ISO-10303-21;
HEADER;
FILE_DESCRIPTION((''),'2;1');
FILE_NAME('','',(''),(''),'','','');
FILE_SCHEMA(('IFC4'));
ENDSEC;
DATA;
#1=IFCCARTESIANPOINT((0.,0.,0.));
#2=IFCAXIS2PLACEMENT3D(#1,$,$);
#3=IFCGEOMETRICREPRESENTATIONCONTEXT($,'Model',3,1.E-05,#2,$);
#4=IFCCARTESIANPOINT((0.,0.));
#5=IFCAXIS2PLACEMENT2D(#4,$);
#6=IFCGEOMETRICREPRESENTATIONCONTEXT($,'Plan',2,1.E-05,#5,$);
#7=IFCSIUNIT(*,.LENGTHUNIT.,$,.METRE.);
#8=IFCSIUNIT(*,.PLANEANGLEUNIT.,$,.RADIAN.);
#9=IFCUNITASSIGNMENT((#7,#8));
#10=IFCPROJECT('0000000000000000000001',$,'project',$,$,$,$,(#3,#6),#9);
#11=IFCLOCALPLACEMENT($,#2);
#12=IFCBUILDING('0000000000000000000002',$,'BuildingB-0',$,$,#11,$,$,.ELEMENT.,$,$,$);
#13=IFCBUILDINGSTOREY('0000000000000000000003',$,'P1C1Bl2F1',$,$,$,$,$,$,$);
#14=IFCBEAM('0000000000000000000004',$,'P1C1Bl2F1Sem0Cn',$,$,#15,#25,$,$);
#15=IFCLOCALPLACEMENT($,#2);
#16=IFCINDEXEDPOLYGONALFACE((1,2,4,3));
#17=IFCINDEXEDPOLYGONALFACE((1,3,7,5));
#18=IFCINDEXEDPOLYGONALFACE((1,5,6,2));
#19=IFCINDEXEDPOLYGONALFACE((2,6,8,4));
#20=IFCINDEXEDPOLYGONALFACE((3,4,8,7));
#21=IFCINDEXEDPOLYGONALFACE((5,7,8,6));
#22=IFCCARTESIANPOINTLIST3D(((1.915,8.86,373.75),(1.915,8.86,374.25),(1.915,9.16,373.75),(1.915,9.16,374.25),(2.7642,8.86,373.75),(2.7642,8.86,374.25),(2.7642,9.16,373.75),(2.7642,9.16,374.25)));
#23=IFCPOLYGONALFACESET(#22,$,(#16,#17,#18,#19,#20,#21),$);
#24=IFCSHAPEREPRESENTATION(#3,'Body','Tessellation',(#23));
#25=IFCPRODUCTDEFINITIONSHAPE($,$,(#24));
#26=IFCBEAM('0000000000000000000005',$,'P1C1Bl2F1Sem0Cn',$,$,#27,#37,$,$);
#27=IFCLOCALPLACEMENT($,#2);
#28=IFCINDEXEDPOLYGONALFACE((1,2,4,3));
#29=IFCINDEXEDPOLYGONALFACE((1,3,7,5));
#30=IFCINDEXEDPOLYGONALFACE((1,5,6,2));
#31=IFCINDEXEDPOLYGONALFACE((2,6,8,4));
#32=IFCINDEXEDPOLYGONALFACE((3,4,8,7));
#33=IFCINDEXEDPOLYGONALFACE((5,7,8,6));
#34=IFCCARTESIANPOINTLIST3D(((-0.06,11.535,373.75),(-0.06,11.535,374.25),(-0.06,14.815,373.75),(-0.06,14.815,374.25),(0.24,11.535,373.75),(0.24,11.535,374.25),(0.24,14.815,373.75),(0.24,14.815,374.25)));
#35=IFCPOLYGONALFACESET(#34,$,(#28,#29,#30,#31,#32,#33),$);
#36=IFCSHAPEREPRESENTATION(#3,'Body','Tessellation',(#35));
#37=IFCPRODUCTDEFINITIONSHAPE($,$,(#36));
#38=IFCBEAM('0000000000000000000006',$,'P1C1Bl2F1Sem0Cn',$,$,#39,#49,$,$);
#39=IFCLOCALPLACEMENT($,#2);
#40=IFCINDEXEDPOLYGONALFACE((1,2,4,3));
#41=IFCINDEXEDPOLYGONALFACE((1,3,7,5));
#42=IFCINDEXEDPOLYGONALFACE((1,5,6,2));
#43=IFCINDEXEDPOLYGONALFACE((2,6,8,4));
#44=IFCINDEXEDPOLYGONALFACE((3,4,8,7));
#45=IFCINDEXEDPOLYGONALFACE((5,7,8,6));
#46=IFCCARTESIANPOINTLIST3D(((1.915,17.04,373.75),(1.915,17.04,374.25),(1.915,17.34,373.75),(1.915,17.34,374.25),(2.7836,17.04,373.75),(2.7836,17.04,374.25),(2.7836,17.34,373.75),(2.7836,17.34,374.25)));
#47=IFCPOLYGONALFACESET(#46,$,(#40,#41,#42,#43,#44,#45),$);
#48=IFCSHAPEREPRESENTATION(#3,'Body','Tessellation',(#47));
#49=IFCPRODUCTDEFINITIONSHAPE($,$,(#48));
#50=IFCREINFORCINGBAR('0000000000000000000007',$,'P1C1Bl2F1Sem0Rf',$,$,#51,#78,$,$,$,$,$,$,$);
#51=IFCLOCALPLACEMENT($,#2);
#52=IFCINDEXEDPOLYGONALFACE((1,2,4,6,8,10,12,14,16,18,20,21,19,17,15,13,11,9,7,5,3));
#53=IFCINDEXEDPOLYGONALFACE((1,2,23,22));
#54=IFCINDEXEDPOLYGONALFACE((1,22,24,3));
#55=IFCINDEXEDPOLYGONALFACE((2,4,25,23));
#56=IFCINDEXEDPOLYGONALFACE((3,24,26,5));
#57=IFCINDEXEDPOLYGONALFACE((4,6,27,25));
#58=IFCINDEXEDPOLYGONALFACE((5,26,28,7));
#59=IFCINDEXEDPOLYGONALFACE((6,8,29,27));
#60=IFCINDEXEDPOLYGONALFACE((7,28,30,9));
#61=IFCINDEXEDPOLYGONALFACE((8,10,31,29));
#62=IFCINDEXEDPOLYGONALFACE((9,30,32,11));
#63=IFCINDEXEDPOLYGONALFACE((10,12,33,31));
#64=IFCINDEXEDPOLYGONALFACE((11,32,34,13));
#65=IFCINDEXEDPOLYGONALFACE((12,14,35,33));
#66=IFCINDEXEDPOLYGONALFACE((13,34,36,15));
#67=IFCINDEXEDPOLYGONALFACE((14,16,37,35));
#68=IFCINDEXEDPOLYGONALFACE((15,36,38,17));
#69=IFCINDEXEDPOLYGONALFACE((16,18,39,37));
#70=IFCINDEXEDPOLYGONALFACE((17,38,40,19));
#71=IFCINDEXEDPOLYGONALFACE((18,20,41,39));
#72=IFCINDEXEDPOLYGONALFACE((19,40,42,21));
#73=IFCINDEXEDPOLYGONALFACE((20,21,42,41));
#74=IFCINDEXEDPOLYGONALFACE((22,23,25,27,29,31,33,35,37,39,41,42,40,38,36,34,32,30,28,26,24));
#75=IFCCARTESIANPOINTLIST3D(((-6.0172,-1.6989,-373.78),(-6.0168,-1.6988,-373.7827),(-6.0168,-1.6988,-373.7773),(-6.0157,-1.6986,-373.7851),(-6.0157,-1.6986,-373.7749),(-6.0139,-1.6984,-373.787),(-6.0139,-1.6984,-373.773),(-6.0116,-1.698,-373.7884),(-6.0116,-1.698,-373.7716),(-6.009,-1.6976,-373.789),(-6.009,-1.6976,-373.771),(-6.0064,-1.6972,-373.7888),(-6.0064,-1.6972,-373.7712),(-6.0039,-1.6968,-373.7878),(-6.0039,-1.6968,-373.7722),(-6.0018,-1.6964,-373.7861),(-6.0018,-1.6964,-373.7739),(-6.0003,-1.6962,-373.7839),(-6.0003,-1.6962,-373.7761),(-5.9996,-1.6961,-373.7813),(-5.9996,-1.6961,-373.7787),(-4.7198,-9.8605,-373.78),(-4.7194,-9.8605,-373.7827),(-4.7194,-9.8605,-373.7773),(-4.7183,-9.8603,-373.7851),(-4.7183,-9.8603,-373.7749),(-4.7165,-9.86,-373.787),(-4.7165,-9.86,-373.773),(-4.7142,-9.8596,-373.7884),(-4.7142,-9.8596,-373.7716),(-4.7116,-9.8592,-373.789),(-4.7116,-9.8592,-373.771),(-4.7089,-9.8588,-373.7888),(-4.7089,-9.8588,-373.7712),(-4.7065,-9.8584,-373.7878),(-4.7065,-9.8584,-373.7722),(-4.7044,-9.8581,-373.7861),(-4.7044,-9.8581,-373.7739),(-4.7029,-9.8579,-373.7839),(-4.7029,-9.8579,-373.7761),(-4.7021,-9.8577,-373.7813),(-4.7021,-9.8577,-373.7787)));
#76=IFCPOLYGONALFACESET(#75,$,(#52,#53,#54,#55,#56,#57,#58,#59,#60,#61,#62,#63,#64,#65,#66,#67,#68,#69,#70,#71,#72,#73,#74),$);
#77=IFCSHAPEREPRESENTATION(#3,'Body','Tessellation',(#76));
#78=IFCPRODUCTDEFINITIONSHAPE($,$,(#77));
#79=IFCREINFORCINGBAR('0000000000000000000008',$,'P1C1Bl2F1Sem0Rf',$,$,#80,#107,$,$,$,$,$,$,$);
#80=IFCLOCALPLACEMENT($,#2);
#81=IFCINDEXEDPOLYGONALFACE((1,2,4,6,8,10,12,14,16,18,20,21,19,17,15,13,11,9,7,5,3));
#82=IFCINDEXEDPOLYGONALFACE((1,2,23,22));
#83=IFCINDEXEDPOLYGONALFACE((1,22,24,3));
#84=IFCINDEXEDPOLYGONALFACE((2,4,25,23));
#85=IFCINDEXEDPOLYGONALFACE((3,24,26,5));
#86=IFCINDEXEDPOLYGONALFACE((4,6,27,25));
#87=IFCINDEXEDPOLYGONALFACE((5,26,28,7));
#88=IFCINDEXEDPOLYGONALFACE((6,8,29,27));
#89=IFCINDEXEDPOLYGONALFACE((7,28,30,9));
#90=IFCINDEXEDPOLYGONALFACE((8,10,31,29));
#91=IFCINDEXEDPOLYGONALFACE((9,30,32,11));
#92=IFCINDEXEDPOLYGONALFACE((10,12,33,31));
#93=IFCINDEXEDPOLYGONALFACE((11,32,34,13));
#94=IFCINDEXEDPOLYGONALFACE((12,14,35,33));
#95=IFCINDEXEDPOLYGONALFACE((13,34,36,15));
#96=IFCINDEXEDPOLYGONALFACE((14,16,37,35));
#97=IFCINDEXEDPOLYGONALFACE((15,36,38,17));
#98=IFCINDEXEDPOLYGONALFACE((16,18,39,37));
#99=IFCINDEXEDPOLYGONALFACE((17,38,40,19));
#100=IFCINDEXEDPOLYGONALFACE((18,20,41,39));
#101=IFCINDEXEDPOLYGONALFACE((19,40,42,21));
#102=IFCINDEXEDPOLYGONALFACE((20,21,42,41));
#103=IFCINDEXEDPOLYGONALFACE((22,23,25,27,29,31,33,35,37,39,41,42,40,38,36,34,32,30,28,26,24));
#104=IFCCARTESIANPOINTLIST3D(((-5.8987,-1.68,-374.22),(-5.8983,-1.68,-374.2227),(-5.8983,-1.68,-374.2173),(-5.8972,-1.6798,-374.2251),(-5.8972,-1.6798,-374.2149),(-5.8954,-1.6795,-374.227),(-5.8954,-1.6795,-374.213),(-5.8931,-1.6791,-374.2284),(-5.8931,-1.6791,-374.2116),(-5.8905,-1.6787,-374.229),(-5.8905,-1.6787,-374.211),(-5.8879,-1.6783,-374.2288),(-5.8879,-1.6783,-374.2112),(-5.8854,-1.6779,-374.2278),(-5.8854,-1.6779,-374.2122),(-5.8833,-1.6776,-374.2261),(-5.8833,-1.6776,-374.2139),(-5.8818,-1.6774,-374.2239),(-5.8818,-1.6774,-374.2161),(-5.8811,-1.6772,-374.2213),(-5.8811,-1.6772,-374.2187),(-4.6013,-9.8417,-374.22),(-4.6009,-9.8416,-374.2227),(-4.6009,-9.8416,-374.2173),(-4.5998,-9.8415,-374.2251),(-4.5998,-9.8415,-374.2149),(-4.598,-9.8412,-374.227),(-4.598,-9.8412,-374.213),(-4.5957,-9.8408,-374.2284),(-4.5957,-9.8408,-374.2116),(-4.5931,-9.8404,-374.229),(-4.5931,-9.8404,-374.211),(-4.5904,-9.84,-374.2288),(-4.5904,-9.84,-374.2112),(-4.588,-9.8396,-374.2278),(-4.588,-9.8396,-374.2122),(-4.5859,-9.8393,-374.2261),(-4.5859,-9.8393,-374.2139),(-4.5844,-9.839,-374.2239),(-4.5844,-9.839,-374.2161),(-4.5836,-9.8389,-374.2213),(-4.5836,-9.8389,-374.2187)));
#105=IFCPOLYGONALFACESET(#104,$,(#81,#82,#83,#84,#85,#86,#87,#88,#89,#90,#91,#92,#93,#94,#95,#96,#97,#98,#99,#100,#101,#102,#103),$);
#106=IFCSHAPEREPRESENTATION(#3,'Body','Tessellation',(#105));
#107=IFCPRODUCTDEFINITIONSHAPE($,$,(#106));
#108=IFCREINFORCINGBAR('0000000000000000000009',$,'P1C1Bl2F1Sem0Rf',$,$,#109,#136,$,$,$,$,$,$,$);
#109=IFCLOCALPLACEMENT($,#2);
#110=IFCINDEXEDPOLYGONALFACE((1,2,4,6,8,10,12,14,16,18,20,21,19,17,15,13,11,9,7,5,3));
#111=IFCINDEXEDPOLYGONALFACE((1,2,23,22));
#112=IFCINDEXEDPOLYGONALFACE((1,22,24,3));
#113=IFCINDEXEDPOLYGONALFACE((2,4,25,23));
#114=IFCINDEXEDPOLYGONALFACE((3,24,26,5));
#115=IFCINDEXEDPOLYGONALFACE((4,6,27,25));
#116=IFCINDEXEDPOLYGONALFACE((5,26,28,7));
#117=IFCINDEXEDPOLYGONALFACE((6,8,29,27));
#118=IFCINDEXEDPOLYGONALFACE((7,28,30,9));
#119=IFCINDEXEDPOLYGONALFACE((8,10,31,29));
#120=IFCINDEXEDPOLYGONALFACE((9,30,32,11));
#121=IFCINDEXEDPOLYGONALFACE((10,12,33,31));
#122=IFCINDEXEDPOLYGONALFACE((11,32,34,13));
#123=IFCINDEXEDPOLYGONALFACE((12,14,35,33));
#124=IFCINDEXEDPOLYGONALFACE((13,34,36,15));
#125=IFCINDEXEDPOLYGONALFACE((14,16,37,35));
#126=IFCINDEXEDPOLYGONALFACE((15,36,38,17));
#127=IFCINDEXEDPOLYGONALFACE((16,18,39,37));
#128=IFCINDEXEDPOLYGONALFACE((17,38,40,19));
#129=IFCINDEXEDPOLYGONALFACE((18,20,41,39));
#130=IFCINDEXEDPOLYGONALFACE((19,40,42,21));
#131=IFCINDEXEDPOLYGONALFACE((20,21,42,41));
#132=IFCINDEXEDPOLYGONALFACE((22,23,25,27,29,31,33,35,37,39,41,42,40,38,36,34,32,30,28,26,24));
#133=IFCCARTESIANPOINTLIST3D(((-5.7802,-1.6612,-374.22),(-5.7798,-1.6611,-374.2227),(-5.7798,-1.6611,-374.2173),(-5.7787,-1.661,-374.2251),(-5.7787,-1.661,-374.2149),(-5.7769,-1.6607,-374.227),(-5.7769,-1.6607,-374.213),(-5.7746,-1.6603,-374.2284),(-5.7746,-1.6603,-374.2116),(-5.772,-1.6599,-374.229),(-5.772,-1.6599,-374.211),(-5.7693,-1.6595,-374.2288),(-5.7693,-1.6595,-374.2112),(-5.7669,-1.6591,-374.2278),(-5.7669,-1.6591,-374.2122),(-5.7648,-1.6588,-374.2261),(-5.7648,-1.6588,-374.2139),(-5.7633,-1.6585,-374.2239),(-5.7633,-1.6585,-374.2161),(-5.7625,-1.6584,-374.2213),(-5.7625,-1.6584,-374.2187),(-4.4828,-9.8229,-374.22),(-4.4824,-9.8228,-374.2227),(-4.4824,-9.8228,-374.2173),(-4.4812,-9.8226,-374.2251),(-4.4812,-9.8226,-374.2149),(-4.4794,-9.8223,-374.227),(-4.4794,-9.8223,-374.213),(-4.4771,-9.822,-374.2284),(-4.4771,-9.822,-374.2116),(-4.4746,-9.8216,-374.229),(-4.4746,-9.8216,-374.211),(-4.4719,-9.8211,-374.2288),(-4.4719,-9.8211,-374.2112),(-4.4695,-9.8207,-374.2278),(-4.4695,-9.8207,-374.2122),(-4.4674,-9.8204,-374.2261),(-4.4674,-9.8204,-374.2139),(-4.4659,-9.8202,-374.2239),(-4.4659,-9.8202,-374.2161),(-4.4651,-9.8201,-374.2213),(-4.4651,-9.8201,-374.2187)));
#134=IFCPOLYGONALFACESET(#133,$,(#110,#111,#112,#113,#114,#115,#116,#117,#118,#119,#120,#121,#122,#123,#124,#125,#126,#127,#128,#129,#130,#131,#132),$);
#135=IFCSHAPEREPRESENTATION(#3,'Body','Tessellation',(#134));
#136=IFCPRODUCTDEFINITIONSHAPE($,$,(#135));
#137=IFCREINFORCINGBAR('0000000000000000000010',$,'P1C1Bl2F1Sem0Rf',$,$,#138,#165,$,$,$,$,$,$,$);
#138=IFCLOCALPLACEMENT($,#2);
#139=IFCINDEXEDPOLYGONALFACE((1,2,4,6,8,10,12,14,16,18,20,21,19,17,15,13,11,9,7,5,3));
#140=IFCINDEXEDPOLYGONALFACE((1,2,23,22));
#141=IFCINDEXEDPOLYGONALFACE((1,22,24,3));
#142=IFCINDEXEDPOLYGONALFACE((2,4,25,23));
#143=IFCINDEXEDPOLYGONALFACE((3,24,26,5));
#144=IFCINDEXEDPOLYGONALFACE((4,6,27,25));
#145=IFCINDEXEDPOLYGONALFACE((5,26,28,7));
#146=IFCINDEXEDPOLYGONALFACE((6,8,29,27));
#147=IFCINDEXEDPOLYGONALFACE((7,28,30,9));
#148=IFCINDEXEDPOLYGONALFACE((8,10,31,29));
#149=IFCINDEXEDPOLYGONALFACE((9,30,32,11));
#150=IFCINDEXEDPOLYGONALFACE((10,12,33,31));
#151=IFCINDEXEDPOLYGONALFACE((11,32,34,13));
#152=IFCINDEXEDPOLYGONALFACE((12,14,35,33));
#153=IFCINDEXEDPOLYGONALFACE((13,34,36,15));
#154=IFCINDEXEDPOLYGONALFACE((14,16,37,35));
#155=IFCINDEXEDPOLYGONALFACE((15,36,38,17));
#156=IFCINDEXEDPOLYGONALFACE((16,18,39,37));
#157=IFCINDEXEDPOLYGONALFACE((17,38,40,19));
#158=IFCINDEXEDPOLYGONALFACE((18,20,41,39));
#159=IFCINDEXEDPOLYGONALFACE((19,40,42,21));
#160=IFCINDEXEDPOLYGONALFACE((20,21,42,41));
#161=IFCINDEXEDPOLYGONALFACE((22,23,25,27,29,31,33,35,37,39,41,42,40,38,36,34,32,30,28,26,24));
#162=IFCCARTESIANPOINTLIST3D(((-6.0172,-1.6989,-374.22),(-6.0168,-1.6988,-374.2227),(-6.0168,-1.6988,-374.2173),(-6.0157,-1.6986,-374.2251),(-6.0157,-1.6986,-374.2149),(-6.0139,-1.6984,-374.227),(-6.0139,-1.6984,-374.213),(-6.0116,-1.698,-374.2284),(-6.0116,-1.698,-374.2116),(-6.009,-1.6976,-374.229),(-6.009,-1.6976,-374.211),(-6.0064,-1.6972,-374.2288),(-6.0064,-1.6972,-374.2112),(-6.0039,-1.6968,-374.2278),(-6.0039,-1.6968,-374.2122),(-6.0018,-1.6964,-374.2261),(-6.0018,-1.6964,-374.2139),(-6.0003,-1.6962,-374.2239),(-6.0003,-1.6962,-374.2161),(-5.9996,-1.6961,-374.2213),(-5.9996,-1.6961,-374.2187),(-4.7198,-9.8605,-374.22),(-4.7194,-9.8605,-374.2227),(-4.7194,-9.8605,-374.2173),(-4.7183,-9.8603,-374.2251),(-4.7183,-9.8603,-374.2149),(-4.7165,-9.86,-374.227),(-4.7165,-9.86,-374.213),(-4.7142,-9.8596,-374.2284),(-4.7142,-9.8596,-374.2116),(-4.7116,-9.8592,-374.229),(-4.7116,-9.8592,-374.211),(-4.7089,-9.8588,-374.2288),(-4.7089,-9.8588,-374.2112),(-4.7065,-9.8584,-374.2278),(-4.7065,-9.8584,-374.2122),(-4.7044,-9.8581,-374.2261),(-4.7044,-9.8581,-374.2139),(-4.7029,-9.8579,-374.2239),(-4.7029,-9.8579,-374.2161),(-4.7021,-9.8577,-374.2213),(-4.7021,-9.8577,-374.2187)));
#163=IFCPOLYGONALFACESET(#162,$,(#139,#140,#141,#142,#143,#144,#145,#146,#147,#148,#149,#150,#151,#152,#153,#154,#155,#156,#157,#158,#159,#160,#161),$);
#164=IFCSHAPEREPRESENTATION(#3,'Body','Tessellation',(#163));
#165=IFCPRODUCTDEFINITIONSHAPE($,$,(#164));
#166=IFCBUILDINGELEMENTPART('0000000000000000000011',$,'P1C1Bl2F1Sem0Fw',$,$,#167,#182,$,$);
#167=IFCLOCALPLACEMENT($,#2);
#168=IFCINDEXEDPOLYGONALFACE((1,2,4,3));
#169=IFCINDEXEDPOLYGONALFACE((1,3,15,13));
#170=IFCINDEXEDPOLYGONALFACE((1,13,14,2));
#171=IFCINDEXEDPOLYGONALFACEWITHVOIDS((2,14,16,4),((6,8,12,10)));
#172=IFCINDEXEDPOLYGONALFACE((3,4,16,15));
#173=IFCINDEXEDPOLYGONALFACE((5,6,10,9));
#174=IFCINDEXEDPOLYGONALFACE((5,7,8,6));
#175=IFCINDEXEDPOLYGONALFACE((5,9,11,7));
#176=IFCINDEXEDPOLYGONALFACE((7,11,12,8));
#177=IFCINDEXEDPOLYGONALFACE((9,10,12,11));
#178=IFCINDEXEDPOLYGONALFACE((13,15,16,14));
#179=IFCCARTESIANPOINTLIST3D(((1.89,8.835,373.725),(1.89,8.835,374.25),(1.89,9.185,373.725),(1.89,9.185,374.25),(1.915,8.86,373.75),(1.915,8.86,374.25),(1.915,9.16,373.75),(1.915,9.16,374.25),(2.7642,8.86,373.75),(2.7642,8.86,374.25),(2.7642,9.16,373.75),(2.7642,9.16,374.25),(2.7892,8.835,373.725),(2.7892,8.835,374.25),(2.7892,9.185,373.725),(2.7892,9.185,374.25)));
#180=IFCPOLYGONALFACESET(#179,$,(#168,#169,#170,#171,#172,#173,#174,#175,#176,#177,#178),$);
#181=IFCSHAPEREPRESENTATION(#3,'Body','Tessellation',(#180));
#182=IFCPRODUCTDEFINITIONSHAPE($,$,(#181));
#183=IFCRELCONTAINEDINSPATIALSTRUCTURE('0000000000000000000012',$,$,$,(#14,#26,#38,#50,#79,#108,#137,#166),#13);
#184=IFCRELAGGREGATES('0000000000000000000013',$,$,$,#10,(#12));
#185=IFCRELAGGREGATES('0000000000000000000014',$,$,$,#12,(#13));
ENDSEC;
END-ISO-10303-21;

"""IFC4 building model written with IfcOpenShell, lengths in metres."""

from ifc_helpers import new_model, entity, si_unit, origin, origin_2d, place, context, project, spatial, polyline, outline, extrude, element, save


model = new_model("IFC4")

# Units and contexts
model_context = context("Model", 3, precision=1e-05, world=origin())
plan_context = context("Plan", 2, precision=1e-05, world=origin_2d())
ifc_project = project(units=[si_unit("LENGTHUNIT", "METRE"), si_unit("PLANEANGLEUNIT", "RADIAN")], contexts=[model_context, plan_context])

# Building, storey
building_placement = place(None, origin())
building = spatial("IfcBuilding", under=ifc_project, at=building_placement, Name="BuildingB-0", CompositionType="ELEMENT")
storey = spatial("IfcBuildingStorey", under=building, Name="P1C1Bl2F1")

# Beams
element("IfcBeam", 1, inside=storey, Name="P1C1Bl2F1Sem0Cn", context=model_context, shape_type="SweptSolid", body=[
    extrude(outline(polyline([(1.915, 8.86, 373.75), (1.915, 9.16, 373.75), (2.7642, 9.16, 373.75), (2.7642, 8.86, 373.75), (1.915, 8.86, 373.75)])), None, (0.0, 0.0, 1.0), 0.5),
])
element("IfcBeam", 2, inside=storey, Name="P1C1Bl2F1Sem0Cn", context=model_context, shape_type="SweptSolid", body=[
    extrude(outline(polyline([(-0.06, 11.535, 373.75), (-0.06, 14.815, 373.75), (0.24, 14.815, 373.75), (0.24, 11.535, 373.75), (-0.06, 11.535, 373.75)])), None, (0.0, 0.0, 1.0), 0.5),
])
element("IfcBeam", 3, inside=storey, Name="P1C1Bl2F1Sem0Cn", context=model_context, shape_type="SweptSolid", body=[
    extrude(outline(polyline([(1.915, 17.04, 373.75), (1.915, 17.34, 373.75), (2.7836, 17.34, 373.75), (2.7836, 17.04, 373.75), (1.915, 17.04, 373.75)])), None, (0.0, 0.0, 1.0), 0.5),
])

# Reinforcing bars
element("IfcReinforcingBar", 4, inside=storey, Name="P1C1Bl2F1Sem0Rf", context=model_context, shape_type="SweptSolid", body=[
    entity("IfcSurfaceCurveSweptAreaSolid", entity("IfcCircleProfileDef", "AREA", None, None, 0.009), None, entity("IfcPolyline", [entity("IfcCartesianPoint", [4.7109, 9.8591, 373.78]), entity("IfcCartesianPoint", [6.0084, 1.6975, 373.78])]), None, None, entity("IfcPlane", entity("IfcAxis2Placement3D", entity("IfcCartesianPoint", [4.7109, 9.8591, 373.78]), entity("IfcDirection", [0.0, 0.0, 1.0]), entity("IfcDirection", [1.0, 0.0, 0.0])))),
])
element("IfcReinforcingBar", 5, inside=storey, Name="P1C1Bl2F1Sem0Rf", context=model_context, shape_type="SweptSolid", body=[
    entity("IfcSurfaceCurveSweptAreaSolid", entity("IfcCircleProfileDef", "AREA", None, None, 0.009), None, entity("IfcPolyline", [entity("IfcCartesianPoint", [4.5924, 9.8403, 374.22]), entity("IfcCartesianPoint", [5.8898, 1.6786, 374.22])]), None, None, entity("IfcPlane", entity("IfcAxis2Placement3D", entity("IfcCartesianPoint", [4.5924, 9.8403, 374.22]), entity("IfcDirection", [0.0, 0.0, 1.0]), entity("IfcDirection", [1.0, 0.0, 0.0])))),
])
element("IfcReinforcingBar", 6, inside=storey, Name="P1C1Bl2F1Sem0Rf", context=model_context, shape_type="SweptSolid", body=[
    entity("IfcSurfaceCurveSweptAreaSolid", entity("IfcCircleProfileDef", "AREA", None, None, 0.009), None, entity("IfcPolyline", [entity("IfcCartesianPoint", [4.4739, 9.8215, 374.22]), entity("IfcCartesianPoint", [5.7713, 1.6598, 374.22])]), None, None, entity("IfcPlane", entity("IfcAxis2Placement3D", entity("IfcCartesianPoint", [4.4739, 9.8215, 374.22]), entity("IfcDirection", [0.0, 0.0, 1.0]), entity("IfcDirection", [1.0, 0.0, 0.0])))),
])
element("IfcReinforcingBar", 7, inside=storey, Name="P1C1Bl2F1Sem0Rf", context=model_context, shape_type="SweptSolid", body=[
    entity("IfcSurfaceCurveSweptAreaSolid", entity("IfcCircleProfileDef", "AREA", None, None, 0.009), None, entity("IfcPolyline", [entity("IfcCartesianPoint", [4.7109, 9.8591, 374.22]), entity("IfcCartesianPoint", [6.0084, 1.6975, 374.22])]), None, None, entity("IfcPlane", entity("IfcAxis2Placement3D", entity("IfcCartesianPoint", [4.7109, 9.8591, 374.22]), entity("IfcDirection", [0.0, 0.0, 1.0]), entity("IfcDirection", [1.0, 0.0, 0.0])))),
])

# Building element part, opening
building_element_part_1 = element("IfcBuildingElementPart", 8, inside=storey, Name="P1C1Bl2F1Sem0Fw", context=model_context, shape_type="SweptSolid", body=[
    extrude(outline(polyline([(1.89, 8.835, 373.725), (1.89, 9.185, 373.725), (2.7892, 9.185, 373.725), (2.7892, 8.835, 373.725), (1.89, 8.835, 373.725)])), None, (0.0, 0.0, 1.0), 0.525),
])
element("IfcOpeningElement", 9, inside=storey, cuts=building_element_part_1, context=model_context, shape_type="SweptSolid", body=[
    extrude(outline(polyline([(1.915, 8.86, 373.75), (1.915, 9.16, 373.75), (2.7642, 9.16, 373.75), (2.7642, 8.86, 373.75), (1.915, 8.86, 373.75)])), None, (0.0, 0.0, 1.0), 0.5),
])

save(model, "model.ifc")
